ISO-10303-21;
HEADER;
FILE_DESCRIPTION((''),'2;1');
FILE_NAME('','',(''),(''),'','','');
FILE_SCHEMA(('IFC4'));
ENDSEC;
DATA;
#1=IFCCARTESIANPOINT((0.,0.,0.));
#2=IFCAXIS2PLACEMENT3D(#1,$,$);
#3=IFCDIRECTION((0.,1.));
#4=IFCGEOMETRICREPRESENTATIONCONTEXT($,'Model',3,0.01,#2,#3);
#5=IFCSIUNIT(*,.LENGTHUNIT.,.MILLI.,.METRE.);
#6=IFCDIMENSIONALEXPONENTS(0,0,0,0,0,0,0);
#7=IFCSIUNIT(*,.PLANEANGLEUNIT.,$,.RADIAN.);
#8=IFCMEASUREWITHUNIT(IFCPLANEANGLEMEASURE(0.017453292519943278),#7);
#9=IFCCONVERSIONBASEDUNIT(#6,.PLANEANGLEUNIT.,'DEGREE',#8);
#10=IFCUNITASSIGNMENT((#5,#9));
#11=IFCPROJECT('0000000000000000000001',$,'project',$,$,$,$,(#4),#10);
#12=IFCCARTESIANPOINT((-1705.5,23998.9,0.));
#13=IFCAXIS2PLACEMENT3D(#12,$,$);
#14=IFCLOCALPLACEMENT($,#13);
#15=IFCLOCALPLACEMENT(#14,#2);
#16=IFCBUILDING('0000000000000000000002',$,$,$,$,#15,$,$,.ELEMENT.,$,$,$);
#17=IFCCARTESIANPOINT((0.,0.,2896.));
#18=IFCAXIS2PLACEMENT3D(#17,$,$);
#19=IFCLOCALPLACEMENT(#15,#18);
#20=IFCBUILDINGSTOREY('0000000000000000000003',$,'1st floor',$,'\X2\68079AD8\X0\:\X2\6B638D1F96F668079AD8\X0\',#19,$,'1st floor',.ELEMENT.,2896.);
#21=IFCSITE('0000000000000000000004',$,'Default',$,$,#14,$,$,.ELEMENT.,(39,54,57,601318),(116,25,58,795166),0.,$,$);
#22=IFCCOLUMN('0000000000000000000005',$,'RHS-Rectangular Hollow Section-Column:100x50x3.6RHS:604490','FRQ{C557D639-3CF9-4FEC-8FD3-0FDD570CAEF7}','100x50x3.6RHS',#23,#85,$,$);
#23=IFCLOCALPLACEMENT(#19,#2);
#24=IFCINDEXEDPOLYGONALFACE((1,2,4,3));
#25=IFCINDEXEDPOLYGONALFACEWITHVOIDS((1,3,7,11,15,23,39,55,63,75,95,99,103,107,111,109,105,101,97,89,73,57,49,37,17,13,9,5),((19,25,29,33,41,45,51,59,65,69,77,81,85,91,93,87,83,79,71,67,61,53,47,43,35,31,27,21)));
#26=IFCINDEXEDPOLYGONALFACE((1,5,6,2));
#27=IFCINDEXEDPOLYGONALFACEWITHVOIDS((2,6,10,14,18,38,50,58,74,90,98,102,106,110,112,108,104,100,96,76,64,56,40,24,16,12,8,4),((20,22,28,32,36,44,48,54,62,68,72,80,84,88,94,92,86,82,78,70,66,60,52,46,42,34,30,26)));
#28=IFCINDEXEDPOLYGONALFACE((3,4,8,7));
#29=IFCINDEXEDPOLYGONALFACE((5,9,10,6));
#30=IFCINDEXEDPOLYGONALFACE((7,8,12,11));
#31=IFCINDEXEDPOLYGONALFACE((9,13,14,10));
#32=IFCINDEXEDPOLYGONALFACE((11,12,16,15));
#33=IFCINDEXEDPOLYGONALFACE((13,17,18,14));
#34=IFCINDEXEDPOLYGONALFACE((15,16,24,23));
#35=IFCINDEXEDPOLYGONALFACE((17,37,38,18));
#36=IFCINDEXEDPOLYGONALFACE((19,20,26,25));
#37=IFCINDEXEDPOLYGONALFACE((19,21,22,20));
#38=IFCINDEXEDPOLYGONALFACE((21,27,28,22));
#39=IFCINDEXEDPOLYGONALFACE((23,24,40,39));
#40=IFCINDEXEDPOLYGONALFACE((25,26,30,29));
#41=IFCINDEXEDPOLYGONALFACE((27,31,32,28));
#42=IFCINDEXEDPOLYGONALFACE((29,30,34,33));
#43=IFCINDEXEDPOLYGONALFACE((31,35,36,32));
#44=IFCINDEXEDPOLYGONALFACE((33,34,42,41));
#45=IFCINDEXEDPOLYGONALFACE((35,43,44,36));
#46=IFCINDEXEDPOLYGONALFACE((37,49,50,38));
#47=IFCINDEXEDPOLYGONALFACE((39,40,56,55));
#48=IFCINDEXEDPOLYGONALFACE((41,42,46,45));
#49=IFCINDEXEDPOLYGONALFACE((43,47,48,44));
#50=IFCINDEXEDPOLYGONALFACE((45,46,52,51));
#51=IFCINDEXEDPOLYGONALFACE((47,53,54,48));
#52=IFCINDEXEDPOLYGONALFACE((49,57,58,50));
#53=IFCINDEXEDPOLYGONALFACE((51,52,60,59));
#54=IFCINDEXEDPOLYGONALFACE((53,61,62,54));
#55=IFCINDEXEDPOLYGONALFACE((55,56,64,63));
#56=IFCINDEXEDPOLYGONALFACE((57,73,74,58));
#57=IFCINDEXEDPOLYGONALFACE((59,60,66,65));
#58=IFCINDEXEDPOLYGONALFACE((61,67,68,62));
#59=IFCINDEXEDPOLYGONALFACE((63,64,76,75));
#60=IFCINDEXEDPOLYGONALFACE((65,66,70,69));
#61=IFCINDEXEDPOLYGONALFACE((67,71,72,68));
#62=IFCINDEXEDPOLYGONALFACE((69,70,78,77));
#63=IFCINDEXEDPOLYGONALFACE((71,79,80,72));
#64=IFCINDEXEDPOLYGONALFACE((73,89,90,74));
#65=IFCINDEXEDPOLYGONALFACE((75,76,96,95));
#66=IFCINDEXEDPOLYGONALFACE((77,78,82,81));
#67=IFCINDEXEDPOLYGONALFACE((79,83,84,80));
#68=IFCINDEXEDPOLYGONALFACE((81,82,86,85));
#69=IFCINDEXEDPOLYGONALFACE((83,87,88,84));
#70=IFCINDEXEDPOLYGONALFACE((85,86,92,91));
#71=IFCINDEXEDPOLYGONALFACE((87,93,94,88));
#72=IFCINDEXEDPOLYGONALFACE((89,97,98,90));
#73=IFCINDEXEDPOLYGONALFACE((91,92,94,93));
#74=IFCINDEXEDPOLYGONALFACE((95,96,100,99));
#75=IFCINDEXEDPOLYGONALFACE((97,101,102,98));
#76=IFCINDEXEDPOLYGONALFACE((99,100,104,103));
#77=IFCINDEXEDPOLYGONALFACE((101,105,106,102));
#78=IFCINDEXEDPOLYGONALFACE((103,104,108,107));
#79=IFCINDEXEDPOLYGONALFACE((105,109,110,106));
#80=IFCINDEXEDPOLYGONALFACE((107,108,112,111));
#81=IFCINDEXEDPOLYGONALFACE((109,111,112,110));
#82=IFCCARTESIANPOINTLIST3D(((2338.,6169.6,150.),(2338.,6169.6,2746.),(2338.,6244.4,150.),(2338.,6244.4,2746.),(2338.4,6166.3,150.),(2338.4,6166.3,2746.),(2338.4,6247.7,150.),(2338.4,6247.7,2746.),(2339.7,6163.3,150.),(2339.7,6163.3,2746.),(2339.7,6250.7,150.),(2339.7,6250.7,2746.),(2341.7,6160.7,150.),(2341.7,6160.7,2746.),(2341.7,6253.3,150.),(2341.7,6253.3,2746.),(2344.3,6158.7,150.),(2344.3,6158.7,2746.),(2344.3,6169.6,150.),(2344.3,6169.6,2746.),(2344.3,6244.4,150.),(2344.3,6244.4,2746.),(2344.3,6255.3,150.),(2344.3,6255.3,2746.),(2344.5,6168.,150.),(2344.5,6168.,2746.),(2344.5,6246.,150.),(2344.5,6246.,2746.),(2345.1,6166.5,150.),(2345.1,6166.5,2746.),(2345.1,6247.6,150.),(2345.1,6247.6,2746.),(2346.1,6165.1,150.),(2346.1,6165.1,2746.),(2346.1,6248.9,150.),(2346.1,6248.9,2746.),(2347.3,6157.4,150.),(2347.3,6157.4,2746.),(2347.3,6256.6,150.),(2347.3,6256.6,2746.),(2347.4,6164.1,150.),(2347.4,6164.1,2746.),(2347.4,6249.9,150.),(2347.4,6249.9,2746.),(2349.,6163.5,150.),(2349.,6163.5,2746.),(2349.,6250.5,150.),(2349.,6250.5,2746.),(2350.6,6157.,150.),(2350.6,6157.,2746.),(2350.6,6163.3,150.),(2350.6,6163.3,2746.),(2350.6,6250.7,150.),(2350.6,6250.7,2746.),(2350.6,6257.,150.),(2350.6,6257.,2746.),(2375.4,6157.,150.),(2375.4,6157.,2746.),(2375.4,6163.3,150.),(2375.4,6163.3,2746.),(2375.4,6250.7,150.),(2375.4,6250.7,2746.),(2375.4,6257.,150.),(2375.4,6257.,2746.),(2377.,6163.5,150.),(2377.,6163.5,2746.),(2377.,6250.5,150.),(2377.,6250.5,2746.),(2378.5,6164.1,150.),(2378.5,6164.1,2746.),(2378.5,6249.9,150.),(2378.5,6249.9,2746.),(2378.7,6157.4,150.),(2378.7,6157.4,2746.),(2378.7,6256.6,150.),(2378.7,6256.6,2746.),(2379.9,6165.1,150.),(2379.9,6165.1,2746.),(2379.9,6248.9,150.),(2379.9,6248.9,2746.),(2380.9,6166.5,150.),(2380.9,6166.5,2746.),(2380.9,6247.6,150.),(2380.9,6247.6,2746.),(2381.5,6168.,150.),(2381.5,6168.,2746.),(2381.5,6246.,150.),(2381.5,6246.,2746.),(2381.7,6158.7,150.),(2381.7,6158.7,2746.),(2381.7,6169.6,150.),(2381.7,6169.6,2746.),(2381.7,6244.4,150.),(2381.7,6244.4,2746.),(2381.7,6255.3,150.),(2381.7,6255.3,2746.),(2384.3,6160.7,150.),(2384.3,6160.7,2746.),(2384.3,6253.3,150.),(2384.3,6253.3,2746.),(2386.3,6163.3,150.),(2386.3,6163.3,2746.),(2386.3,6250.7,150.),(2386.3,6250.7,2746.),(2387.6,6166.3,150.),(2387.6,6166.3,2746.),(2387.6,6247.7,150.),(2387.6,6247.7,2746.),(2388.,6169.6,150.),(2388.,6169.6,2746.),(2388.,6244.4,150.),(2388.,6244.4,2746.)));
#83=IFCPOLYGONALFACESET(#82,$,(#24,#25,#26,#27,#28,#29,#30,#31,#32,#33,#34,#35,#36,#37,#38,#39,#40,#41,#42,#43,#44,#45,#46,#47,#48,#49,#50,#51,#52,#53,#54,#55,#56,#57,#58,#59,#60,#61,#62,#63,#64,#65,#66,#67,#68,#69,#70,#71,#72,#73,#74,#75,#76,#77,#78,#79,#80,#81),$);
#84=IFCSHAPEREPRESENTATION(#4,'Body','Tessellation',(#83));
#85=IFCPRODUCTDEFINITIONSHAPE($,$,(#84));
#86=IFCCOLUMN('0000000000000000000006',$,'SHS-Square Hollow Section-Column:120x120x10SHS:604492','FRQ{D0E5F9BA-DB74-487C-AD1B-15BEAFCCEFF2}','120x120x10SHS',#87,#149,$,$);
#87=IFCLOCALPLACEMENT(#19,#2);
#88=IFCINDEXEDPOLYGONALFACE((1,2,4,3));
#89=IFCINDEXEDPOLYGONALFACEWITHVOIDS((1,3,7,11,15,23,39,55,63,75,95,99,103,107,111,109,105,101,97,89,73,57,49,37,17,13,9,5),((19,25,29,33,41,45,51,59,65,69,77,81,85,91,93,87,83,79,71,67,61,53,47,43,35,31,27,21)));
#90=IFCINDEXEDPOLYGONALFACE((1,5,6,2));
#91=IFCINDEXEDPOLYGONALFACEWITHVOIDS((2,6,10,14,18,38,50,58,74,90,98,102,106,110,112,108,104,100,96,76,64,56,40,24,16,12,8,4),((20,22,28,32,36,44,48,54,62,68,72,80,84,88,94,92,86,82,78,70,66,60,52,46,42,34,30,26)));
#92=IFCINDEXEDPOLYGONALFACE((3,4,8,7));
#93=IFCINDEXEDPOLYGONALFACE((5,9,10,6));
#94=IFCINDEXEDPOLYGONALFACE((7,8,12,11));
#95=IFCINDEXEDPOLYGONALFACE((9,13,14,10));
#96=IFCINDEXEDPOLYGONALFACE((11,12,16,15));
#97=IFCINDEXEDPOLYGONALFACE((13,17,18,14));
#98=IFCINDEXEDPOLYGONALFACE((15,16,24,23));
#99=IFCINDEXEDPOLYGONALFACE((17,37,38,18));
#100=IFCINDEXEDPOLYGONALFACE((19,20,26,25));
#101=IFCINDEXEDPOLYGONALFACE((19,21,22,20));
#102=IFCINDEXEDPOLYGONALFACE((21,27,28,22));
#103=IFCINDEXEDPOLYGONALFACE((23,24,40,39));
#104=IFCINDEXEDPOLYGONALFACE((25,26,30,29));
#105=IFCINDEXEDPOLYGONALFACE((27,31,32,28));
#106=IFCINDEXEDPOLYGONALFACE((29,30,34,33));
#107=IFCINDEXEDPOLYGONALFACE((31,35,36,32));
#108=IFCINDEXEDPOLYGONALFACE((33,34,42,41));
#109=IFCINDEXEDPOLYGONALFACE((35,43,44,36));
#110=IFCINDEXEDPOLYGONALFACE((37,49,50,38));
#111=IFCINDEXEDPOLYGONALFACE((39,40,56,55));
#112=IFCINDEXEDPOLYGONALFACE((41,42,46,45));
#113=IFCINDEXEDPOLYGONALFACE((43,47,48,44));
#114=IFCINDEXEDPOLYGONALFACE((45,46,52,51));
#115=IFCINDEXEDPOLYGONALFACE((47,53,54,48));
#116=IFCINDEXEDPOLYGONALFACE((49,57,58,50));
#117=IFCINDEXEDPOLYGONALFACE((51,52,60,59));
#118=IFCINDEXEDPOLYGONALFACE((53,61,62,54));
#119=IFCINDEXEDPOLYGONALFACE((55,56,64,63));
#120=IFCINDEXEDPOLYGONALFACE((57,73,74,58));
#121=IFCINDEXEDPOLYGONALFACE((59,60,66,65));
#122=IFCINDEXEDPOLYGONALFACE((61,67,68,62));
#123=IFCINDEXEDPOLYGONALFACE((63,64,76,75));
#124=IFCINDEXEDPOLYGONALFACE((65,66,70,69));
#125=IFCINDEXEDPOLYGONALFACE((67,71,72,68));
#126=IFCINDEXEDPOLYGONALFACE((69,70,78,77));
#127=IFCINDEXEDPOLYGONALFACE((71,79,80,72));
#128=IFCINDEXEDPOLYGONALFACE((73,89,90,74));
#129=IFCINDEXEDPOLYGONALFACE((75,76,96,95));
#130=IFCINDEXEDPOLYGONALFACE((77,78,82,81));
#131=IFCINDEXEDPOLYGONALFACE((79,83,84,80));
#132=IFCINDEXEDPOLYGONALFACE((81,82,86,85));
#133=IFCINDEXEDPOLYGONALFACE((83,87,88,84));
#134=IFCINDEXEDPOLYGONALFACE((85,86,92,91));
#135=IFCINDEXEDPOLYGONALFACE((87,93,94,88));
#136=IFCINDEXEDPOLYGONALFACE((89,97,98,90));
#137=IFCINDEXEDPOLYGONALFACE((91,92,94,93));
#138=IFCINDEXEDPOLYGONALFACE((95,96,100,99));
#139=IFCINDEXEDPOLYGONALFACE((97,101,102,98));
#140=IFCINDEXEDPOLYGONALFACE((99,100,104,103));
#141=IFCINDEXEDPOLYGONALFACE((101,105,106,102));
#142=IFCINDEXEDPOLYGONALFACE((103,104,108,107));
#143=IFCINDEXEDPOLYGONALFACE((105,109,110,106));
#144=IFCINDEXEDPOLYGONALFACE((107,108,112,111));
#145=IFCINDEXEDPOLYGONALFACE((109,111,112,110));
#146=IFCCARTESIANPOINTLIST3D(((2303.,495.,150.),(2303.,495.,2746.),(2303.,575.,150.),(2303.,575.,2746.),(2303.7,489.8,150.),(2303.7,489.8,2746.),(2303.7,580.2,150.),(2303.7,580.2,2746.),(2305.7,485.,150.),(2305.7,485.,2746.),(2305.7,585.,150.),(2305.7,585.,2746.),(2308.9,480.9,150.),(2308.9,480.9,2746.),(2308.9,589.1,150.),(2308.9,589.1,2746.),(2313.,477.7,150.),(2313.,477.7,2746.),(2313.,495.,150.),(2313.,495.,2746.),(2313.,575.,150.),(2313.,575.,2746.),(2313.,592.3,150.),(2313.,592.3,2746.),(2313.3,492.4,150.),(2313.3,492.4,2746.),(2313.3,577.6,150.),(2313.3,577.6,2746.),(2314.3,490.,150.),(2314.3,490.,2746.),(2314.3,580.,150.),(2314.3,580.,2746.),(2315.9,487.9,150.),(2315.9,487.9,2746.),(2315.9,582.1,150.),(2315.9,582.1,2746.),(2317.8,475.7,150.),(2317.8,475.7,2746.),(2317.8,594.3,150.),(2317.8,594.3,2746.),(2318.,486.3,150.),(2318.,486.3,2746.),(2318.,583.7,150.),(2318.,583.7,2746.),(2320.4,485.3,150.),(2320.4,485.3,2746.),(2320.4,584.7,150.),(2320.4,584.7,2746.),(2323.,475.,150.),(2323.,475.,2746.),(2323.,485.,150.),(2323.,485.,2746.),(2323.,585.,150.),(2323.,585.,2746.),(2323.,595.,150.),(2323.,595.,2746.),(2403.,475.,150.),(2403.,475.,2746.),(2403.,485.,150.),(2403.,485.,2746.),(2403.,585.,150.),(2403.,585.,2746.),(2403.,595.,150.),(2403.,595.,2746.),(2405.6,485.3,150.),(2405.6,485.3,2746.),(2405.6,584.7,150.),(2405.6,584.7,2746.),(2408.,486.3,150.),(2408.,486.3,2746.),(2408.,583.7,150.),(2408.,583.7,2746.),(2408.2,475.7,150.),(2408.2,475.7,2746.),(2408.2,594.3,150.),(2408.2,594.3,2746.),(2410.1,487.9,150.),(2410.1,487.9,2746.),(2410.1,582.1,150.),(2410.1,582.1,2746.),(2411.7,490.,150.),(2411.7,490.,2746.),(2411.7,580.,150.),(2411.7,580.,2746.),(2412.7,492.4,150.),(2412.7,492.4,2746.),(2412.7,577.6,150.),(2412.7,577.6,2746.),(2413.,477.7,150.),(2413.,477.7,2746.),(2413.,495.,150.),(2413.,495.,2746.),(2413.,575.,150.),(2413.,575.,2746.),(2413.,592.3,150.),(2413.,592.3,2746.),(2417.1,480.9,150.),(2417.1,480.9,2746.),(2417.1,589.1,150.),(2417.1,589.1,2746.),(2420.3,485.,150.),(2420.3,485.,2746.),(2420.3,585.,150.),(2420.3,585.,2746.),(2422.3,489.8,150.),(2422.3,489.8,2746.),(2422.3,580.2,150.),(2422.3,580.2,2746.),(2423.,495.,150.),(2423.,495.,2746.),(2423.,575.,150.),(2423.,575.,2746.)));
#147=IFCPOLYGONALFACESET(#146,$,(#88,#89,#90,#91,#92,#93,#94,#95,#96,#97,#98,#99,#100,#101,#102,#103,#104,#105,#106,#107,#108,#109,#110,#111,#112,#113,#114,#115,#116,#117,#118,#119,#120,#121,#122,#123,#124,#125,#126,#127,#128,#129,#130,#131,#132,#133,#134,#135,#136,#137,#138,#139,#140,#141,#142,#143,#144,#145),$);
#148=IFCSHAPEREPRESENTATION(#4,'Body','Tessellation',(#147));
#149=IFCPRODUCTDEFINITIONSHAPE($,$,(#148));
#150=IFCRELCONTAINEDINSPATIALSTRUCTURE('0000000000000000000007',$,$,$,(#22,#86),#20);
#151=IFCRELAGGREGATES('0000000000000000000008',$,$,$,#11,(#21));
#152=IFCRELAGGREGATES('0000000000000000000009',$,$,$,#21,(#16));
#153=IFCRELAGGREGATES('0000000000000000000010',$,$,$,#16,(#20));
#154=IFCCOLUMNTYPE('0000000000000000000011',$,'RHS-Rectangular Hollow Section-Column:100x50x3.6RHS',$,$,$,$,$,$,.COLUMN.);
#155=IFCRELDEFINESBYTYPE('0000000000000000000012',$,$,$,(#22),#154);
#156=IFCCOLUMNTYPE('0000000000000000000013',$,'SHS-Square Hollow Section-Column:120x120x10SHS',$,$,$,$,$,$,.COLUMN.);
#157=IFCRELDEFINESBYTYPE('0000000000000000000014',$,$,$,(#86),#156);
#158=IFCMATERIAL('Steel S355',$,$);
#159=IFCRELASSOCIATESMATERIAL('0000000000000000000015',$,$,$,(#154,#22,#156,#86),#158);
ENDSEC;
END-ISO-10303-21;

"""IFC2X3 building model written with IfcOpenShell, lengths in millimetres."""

from ifc_helpers import new_model, entity, si_unit, converted_unit, direction, frame, origin, origin_2d, place, context, project, spatial, hollow_rectangle, extrude, clip, halfspace, material, type_object, element, save


model = new_model("IFC2X3")

# Units and contexts
model_context = context("Model", 3, precision=0.01, world=origin(), true_north=direction((0.0, 1.0)))
ifc_project = project(units=[si_unit("LENGTHUNIT", "METRE", prefix="MILLI"), converted_unit("PLANEANGLEUNIT", "DEGREE", entity("IfcPlaneAngleMeasure", 0.017453292519943278), si_unit("PLANEANGLEUNIT", "RADIAN"), dimensions=[0, 0, 0, 0, 0, 0, 0])], contexts=[model_context])

# Site, building, storey
site_placement = place(None, frame((-1705.5, 23998.9, 0.0)))
site = spatial("IfcSite", under=ifc_project, at=site_placement, Name="Default", CompositionType="ELEMENT", RefLatitude=(39, 54, 57, 601318), RefLongitude=(116, 25, 58, 795166), RefElevation=0.0)
building_placement = place(site_placement, origin())
building = spatial("IfcBuilding", under=site, at=building_placement, CompositionType="ELEMENT")
storey_placement = place(building_placement, frame((0.0, 0.0, 2896.0)))
storey = spatial("IfcBuildingStorey", under=building, at=storey_placement, Name="1st floor", ObjectType="标高:正负零标高", LongName="1st floor", CompositionType="ELEMENT", Elevation=2896.0)

# Columns
ifc_material_1 = material(Name="Steel S355")
column_type_1 = type_object("IfcColumnType", Name="RHS-Rectangular Hollow Section-Column:100x50x3.6RHS", PredefinedType="COLUMN", material=ifc_material_1)
column_1_placement = place(storey_placement, frame((2363.0, 6207.0, 2746.0), z_axis=(0.0, 0.0, 1.0), x_axis=(-1.0, 0.0, 0.0)))
element("IfcColumn", 1, at=column_1_placement, inside=storey, type_object=column_type_1, material=ifc_material_1, Name="RHS-Rectangular Hollow Section-Column:100x50x3.6RHS:604490", Description="FRQ{C557D639-3CF9-4FEC-8FD3-0FDD570CAEF7}", ObjectType="100x50x3.6RHS", context=model_context, shape_type="Clipping", body=[
    clip(extrude(hollow_rectangle(XDim=50.0, YDim=100.0, WallThickness=6.3, InnerFilletRadius=6.3, OuterFilletRadius=12.6, at=origin_2d()), origin(), (0.0, 0.0, -1.0), 2651.9), halfspace(frame((2363.0, 6207.0, -2596.0), z_axis=(0.0, 0.0, 1.0), x_axis=(-1.0, 0.0, 0.0)), True)),
])
column_type_2 = type_object("IfcColumnType", Name="SHS-Square Hollow Section-Column:120x120x10SHS", PredefinedType="COLUMN", material=ifc_material_1)
column_2_placement = place(storey_placement, frame((2363.0, 535.0, 2746.0), z_axis=(0.0, 0.0, 1.0), x_axis=(0.0, -1.0, 0.0)))
element("IfcColumn", 2, at=column_2_placement, inside=storey, type_object=column_type_2, material=ifc_material_1, Name="SHS-Square Hollow Section-Column:120x120x10SHS:604492", Description="FRQ{D0E5F9BA-DB74-487C-AD1B-15BEAFCCEFF2}", ObjectType="120x120x10SHS", context=model_context, shape_type="Clipping", body=[
    clip(extrude(hollow_rectangle(XDim=120.0, YDim=120.0, WallThickness=10.0, InnerFilletRadius=10.0, OuterFilletRadius=20.0, at=origin_2d()), origin(), (0.0, 0.0, -1.0), 2680.9), halfspace(frame((535.0, -2363.0, -2596.0), z_axis=(0.0, 0.0, 1.0), x_axis=(0.0, 1.0, 0.0)), True)),
])

save(model, "model.ifc")
